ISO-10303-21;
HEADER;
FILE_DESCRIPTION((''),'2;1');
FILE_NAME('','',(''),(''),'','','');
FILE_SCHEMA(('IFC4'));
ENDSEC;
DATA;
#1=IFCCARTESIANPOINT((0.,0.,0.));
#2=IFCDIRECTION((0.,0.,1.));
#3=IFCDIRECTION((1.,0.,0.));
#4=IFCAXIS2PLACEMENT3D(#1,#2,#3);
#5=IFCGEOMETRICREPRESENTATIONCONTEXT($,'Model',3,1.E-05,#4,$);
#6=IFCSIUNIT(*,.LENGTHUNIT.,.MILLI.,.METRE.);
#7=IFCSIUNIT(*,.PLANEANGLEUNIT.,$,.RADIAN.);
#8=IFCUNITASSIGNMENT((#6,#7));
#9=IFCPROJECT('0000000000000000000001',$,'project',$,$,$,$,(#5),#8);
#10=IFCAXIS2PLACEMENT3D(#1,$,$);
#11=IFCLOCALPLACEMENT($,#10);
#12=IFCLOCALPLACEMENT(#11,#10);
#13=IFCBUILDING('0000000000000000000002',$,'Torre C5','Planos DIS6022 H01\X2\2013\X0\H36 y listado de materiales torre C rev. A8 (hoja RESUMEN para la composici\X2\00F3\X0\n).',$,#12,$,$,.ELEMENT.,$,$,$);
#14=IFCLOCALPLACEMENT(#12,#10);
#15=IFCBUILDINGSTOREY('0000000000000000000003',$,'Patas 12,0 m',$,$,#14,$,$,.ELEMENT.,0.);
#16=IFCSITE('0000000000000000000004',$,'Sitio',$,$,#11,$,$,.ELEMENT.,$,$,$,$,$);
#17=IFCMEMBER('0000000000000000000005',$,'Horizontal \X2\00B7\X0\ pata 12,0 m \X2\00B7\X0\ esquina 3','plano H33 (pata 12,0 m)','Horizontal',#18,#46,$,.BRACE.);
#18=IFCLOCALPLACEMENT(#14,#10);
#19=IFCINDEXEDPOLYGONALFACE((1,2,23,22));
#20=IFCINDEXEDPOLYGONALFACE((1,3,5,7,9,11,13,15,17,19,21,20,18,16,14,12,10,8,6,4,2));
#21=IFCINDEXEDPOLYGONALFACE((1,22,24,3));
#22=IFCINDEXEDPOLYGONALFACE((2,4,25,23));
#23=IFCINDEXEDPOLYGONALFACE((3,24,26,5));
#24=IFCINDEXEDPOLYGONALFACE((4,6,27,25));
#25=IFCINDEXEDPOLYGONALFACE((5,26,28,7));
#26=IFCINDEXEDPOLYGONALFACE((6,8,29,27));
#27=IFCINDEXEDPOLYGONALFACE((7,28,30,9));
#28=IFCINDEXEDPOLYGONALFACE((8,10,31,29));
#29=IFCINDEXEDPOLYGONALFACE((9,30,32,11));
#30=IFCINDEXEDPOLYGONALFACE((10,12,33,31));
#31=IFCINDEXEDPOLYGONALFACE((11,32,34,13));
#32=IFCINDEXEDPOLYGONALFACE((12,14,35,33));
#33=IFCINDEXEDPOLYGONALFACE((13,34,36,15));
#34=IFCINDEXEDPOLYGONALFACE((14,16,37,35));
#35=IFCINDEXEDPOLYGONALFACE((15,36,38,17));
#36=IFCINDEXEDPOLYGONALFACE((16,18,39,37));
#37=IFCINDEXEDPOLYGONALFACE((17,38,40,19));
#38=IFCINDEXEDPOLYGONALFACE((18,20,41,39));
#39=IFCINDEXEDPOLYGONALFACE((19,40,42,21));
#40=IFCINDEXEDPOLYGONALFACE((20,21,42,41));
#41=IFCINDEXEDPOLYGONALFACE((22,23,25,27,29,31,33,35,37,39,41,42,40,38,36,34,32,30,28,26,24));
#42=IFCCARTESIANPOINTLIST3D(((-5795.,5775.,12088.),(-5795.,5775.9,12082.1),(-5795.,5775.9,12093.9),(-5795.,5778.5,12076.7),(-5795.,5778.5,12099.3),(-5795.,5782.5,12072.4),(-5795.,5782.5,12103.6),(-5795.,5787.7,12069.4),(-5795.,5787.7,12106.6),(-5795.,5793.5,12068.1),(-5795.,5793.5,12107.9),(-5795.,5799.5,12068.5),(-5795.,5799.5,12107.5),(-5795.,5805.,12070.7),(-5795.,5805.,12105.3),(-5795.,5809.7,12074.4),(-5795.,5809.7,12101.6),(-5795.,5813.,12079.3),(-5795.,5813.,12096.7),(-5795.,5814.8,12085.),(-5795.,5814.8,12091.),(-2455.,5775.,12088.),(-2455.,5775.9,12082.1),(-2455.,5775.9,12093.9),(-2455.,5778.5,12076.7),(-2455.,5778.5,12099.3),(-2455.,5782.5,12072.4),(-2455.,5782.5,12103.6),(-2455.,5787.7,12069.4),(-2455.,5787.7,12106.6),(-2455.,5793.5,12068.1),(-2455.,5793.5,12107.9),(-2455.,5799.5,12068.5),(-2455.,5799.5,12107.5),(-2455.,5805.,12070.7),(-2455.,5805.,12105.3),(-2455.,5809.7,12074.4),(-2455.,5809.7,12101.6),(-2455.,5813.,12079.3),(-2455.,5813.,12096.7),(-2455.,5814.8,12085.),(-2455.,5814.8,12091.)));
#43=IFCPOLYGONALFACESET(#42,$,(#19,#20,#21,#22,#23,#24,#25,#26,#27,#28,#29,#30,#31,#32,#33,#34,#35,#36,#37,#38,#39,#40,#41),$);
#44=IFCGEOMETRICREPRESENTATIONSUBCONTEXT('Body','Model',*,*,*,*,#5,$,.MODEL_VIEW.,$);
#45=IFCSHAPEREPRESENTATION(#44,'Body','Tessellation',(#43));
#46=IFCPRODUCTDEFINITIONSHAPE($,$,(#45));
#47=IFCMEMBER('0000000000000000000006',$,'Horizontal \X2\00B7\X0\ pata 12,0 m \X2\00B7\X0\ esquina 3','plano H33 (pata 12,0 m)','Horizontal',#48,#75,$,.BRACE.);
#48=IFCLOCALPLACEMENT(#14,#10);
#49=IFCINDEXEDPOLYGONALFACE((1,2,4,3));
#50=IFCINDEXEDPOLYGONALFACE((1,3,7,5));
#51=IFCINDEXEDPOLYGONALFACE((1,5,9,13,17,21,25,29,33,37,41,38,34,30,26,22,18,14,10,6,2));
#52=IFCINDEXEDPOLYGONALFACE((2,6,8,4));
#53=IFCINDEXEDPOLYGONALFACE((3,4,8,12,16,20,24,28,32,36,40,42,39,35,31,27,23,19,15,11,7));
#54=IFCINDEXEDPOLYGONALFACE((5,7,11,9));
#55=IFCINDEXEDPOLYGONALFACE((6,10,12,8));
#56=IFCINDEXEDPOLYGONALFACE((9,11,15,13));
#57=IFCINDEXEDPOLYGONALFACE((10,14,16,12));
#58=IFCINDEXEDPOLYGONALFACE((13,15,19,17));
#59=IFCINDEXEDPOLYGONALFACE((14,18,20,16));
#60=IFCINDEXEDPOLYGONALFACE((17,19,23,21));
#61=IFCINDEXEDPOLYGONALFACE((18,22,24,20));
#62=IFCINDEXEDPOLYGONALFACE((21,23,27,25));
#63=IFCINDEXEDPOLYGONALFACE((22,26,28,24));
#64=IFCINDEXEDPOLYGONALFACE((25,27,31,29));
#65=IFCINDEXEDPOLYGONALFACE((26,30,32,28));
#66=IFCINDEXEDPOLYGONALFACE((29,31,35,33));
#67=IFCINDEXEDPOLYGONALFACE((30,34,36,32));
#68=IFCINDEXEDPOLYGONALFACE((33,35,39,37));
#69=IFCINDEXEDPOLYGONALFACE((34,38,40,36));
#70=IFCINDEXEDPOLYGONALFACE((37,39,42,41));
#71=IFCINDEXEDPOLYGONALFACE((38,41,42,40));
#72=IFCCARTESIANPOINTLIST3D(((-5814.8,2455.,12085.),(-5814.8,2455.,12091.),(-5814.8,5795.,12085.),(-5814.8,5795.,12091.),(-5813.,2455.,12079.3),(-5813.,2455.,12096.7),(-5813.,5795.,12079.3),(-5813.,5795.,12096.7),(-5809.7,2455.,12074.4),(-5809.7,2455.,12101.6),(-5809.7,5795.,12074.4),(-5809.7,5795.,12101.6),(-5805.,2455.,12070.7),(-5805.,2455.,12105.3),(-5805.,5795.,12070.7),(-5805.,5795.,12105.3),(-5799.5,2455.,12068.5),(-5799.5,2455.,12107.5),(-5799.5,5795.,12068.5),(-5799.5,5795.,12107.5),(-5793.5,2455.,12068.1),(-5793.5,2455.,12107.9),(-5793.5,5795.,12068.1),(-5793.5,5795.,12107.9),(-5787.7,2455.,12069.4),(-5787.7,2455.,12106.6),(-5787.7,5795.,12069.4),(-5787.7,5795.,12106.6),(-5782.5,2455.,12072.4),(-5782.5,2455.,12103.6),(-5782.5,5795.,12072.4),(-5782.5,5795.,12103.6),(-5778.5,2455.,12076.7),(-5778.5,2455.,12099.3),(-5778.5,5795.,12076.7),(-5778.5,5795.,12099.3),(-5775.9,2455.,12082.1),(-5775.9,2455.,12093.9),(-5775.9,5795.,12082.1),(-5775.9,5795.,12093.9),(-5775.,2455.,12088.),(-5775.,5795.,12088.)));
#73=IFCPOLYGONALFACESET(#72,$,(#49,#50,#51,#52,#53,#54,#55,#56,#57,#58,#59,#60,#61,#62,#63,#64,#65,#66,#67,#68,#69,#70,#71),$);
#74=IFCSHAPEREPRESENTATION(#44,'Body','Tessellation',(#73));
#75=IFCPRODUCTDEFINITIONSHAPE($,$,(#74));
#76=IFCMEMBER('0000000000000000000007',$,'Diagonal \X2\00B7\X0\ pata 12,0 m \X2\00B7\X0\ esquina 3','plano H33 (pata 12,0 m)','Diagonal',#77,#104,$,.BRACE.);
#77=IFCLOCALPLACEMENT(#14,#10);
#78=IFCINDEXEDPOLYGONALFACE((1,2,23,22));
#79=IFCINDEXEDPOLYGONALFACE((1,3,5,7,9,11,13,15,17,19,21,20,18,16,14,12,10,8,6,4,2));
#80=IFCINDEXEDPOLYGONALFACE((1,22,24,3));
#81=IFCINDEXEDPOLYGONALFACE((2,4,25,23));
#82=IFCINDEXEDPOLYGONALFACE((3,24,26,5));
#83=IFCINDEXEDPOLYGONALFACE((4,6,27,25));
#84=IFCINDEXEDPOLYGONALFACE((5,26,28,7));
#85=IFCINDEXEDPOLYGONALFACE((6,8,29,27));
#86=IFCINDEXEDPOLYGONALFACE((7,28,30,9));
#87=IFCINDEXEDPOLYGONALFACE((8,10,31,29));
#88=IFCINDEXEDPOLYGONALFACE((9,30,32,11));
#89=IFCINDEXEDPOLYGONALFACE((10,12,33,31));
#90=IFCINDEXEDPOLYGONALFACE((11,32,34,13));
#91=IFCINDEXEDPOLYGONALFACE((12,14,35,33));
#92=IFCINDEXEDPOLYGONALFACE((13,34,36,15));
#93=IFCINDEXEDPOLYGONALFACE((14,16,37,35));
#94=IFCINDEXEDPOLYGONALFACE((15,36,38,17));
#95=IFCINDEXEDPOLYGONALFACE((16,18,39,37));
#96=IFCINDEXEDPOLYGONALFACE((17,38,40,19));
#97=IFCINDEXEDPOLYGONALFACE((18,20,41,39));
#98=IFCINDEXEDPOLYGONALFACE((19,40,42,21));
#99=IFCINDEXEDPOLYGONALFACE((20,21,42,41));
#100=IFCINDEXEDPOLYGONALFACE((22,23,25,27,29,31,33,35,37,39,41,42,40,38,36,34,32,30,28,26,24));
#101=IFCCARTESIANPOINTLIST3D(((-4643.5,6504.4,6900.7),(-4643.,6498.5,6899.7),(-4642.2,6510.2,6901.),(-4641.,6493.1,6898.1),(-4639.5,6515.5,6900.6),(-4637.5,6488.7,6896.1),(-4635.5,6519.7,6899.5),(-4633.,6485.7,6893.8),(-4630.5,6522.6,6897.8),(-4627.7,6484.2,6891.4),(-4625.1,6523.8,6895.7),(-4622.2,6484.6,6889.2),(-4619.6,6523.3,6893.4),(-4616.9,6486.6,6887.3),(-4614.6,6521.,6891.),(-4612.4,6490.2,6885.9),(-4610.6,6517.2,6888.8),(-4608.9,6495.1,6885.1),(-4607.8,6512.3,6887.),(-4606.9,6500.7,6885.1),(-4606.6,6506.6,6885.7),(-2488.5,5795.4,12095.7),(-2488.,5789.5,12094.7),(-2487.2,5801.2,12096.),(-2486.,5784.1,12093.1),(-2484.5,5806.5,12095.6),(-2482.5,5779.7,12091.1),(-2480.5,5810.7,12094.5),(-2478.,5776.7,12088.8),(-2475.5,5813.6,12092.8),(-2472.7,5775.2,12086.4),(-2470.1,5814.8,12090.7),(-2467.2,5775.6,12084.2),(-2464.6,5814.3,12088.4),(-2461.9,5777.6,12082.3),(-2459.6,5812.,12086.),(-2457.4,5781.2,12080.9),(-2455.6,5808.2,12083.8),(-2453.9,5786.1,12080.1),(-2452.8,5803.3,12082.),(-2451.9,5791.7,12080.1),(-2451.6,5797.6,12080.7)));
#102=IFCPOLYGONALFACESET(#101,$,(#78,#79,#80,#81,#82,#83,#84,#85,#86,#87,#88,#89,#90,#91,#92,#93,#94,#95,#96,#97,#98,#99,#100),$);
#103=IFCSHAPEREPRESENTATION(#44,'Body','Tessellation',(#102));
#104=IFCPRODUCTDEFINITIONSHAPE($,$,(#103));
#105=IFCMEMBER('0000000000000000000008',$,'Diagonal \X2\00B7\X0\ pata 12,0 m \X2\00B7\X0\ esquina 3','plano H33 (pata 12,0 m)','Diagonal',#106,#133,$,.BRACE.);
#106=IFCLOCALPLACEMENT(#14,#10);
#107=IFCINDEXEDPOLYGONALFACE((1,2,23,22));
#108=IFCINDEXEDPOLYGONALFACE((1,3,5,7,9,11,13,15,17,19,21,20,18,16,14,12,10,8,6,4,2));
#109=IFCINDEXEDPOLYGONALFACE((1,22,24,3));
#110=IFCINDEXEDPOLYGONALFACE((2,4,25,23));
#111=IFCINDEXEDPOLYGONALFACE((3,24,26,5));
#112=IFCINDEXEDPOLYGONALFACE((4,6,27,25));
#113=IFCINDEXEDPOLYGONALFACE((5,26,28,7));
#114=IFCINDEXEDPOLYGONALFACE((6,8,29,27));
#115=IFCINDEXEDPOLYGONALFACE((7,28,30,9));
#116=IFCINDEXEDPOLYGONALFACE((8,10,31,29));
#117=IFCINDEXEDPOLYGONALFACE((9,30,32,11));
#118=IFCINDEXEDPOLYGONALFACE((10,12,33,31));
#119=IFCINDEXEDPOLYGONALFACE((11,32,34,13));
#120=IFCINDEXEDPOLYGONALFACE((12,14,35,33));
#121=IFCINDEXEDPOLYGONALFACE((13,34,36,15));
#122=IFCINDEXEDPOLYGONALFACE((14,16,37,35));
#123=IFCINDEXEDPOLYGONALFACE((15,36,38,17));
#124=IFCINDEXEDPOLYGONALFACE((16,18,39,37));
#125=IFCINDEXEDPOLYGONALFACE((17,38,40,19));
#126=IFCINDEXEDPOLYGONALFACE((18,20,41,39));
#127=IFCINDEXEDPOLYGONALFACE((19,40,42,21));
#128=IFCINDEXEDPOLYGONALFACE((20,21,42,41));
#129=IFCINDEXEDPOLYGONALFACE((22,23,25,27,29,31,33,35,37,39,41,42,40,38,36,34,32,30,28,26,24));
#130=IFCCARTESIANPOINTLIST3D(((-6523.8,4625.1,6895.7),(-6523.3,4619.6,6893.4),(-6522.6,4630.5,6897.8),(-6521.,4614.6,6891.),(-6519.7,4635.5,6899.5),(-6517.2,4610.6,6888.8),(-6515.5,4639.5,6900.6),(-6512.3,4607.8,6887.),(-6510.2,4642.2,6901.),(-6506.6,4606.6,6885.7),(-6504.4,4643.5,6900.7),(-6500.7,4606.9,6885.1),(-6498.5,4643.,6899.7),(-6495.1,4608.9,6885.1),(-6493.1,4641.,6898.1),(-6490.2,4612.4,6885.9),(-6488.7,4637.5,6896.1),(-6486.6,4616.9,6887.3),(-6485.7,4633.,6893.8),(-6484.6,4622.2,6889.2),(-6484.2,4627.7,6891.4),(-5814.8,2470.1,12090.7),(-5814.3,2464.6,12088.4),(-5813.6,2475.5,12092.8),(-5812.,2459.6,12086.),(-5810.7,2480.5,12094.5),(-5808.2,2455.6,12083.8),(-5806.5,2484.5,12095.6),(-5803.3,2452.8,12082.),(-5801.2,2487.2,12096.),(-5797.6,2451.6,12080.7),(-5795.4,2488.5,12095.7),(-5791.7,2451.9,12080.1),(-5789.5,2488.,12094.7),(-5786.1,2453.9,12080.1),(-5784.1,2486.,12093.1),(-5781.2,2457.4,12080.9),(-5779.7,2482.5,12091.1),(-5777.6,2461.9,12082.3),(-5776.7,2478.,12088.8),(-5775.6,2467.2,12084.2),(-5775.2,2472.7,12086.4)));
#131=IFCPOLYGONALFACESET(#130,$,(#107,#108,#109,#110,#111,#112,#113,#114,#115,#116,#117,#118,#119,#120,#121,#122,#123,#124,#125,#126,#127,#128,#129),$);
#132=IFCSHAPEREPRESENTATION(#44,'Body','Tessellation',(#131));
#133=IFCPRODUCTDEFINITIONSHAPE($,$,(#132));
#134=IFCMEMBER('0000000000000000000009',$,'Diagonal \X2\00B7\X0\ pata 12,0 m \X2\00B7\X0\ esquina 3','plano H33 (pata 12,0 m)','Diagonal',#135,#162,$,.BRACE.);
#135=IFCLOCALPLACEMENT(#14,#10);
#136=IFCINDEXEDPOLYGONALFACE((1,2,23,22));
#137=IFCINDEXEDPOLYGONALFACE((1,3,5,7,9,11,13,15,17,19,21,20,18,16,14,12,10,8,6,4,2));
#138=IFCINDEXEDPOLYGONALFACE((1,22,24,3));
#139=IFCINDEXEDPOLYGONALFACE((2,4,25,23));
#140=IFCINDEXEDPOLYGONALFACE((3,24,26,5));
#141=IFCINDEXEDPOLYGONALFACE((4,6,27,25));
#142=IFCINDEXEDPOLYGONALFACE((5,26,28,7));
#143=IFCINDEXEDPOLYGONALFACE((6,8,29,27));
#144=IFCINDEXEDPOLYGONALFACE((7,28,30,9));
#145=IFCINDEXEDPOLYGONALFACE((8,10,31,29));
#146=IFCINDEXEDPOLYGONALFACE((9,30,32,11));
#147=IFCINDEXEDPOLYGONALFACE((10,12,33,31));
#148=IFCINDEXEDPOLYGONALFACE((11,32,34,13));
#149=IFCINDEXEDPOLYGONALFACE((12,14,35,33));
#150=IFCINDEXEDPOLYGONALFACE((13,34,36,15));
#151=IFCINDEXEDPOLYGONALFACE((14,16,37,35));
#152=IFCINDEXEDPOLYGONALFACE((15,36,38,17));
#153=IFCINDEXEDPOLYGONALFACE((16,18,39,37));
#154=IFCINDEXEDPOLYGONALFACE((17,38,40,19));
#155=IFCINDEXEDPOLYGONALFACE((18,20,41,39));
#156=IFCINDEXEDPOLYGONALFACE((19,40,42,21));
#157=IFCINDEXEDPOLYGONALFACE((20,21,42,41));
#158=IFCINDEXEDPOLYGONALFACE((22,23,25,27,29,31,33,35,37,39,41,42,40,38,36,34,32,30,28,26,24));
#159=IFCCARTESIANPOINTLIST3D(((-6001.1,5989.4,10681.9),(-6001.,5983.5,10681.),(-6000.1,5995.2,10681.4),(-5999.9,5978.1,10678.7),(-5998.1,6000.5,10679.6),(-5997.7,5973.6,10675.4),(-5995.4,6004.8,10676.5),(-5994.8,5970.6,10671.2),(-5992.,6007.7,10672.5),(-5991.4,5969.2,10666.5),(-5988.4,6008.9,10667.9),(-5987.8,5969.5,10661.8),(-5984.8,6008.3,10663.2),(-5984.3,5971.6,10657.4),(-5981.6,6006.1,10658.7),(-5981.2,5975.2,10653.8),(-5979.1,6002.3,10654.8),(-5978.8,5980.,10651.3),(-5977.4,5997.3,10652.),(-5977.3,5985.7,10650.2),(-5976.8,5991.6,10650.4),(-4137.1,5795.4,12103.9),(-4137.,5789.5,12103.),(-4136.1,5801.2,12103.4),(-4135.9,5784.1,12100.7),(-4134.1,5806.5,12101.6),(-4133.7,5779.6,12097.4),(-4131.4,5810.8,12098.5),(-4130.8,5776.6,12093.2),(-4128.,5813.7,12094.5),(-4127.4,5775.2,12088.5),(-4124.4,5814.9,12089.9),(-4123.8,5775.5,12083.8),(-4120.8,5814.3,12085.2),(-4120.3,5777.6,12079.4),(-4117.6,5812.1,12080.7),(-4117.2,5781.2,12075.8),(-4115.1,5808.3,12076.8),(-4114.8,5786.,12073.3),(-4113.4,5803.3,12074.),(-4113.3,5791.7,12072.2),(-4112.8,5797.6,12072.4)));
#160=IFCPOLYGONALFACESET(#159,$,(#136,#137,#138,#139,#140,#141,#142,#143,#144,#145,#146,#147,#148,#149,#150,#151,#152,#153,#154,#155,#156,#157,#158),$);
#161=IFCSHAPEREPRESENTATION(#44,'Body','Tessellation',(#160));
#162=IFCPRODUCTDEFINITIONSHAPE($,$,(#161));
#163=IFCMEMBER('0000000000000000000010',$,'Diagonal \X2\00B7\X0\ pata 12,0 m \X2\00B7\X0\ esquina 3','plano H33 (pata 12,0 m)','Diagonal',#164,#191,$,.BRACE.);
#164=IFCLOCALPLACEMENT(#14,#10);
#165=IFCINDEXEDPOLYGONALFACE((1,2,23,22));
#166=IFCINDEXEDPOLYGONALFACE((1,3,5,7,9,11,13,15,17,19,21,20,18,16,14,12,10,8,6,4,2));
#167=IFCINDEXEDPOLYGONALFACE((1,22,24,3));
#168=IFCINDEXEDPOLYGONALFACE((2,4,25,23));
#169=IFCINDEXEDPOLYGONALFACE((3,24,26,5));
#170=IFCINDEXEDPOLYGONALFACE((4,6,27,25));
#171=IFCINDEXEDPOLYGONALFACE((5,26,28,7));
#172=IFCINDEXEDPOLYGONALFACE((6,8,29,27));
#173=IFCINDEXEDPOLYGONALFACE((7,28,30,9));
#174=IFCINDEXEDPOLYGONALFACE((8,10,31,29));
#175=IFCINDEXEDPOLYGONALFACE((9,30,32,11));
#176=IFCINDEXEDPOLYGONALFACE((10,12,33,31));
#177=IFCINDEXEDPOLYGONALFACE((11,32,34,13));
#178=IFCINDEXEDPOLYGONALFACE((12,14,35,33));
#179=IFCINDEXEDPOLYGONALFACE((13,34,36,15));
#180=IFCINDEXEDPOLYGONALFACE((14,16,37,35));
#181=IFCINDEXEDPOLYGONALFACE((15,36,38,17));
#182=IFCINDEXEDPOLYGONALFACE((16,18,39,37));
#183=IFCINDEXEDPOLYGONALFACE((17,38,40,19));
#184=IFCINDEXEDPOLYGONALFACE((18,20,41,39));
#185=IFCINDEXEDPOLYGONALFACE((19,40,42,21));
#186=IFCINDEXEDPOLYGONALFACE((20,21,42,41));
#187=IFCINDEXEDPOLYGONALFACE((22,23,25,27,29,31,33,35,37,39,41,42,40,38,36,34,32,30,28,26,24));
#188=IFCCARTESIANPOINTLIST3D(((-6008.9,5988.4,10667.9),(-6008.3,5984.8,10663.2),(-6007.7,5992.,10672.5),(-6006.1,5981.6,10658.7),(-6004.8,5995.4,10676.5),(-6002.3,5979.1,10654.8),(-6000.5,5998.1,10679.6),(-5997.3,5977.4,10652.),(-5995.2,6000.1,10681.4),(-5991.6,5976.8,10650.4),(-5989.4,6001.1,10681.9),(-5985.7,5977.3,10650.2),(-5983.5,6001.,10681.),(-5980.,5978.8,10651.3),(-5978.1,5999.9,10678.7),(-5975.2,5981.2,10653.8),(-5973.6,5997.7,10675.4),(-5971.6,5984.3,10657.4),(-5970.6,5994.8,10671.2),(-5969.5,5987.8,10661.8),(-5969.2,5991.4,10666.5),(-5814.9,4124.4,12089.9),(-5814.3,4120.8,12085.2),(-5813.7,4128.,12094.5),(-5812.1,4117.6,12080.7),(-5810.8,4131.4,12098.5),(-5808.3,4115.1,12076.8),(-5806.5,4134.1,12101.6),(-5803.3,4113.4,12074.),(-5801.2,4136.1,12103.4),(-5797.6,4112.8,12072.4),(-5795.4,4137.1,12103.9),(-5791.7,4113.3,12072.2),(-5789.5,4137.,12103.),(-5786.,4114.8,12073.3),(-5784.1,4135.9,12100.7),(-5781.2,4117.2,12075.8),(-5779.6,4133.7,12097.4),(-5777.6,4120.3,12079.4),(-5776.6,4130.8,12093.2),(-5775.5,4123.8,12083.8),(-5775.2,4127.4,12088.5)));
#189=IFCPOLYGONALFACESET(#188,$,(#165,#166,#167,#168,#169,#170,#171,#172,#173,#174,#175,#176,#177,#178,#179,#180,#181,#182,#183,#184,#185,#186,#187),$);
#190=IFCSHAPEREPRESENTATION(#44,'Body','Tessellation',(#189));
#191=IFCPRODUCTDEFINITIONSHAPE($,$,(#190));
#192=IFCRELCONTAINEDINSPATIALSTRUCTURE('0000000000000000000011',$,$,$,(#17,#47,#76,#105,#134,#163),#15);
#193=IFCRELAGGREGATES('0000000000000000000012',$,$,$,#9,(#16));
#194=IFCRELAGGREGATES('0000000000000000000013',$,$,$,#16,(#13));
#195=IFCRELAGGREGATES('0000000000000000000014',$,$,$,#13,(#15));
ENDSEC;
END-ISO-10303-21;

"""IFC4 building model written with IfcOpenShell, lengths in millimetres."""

from ifc_helpers import new_model, si_unit, frame, origin, origin_with_axes, place, context, subcontext, project, spatial, circle, extrude, element, save


model = new_model("IFC4")

# Units and contexts
model_context = context("Model", 3, precision=1e-05, world=origin_with_axes())
body_context = subcontext(model_context, "Body", "Model", "MODEL_VIEW")
ifc_project = project(units=[si_unit("LENGTHUNIT", "METRE", prefix="MILLI"), si_unit("PLANEANGLEUNIT", "RADIAN")], contexts=[model_context])

# Site, building, storey
site_placement = place(None, origin())
site = spatial("IfcSite", under=ifc_project, at=site_placement, Name="Sitio", CompositionType="ELEMENT")
building_placement = place(site_placement, origin())
building = spatial("IfcBuilding", under=site, at=building_placement, Name="Torre C5", Description="Planos DIS6022 H01–H36 y listado de materiales torre C rev. A8 (hoja RESUMEN para la composición).", CompositionType="ELEMENT")
storey_placement = place(building_placement, origin())
storey = spatial("IfcBuildingStorey", under=building, at=storey_placement, Name="Patas 12,0 m", CompositionType="ELEMENT", Elevation=0.0)

# Members
for number, where, z_axis, x_axis, name in (
    (1, (-5795.0, 5795.0, 12088.0), (1.0, 0.0, 0.0), (0.0, -1.0, 0.0), "Horizontal · pata 12,0 m · esquina 3"),
    (2, (-5795.0, 5795.0, 12088.0), (0.0, -1.0, 0.0), (1.0, 0.0, 0.0), "Horizontal · pata 12,0 m · esquina 3"),
):
    element("IfcMember", number, at=place(storey_placement, frame(where, z_axis=z_axis, x_axis=x_axis)), inside=storey, Name=name, Description="plano H33 (pata 12,0 m)", ObjectType="Horizontal", PredefinedType="BRACE", context=body_context, shape_type="SweptSolid", body=[
        extrude(circle(Radius=20.0), None, (0.0, 0.0, 1.0), 3340.0),
    ])
for number, where, z_axis, x_axis, name in (
    (3, (-2470.0, 5795.0, 12088.0), (-0.380154, 0.125072, -0.916428), (0.404719, -0.868432, -0.286407), "Diagonal · pata 12,0 m · esquina 3"),
    (4, (-5795.0, 2470.0, 12088.0), (-0.125072, 0.380154, -0.916428), (0.868432, -0.404719, -0.286407), "Diagonal · pata 12,0 m · esquina 3"),
):
    element("IfcMember", number, at=place(storey_placement, frame(where, z_axis=z_axis, x_axis=x_axis)), inside=storey, Name=name, Description="plano H33 (pata 12,0 m)", ObjectType="Diagonal", PredefinedType="BRACE", context=body_context, shape_type="SweptSolid", body=[
        extrude(circle(Radius=20.0), None, (0.0, 0.0, 1.0), 5668.8),
    ])
for number, where, z_axis, x_axis, name in (
    (5, (-4125.0, 5795.0, 12088.0), (-0.792351, 0.082466, -0.604466), (0.236409, -0.871897, -0.428843), "Diagonal · pata 12,0 m · esquina 3"),
    (6, (-5795.0, 4125.0, 12088.0), (-0.082466, 0.792351, -0.604466), (0.871897, -0.236409, -0.428843), "Diagonal · pata 12,0 m · esquina 3"),
):
    element("IfcMember", number, at=place(storey_placement, frame(where, z_axis=z_axis, x_axis=x_axis)), inside=storey, Name=name, Description="plano H33 (pata 12,0 m)", ObjectType="Diagonal", PredefinedType="BRACE", context=body_context, shape_type="SweptSolid", body=[
        extrude(circle(Radius=20.0), None, (0.0, 0.0, 1.0), 2352.5),
    ])

save(model, "model.ifc")
